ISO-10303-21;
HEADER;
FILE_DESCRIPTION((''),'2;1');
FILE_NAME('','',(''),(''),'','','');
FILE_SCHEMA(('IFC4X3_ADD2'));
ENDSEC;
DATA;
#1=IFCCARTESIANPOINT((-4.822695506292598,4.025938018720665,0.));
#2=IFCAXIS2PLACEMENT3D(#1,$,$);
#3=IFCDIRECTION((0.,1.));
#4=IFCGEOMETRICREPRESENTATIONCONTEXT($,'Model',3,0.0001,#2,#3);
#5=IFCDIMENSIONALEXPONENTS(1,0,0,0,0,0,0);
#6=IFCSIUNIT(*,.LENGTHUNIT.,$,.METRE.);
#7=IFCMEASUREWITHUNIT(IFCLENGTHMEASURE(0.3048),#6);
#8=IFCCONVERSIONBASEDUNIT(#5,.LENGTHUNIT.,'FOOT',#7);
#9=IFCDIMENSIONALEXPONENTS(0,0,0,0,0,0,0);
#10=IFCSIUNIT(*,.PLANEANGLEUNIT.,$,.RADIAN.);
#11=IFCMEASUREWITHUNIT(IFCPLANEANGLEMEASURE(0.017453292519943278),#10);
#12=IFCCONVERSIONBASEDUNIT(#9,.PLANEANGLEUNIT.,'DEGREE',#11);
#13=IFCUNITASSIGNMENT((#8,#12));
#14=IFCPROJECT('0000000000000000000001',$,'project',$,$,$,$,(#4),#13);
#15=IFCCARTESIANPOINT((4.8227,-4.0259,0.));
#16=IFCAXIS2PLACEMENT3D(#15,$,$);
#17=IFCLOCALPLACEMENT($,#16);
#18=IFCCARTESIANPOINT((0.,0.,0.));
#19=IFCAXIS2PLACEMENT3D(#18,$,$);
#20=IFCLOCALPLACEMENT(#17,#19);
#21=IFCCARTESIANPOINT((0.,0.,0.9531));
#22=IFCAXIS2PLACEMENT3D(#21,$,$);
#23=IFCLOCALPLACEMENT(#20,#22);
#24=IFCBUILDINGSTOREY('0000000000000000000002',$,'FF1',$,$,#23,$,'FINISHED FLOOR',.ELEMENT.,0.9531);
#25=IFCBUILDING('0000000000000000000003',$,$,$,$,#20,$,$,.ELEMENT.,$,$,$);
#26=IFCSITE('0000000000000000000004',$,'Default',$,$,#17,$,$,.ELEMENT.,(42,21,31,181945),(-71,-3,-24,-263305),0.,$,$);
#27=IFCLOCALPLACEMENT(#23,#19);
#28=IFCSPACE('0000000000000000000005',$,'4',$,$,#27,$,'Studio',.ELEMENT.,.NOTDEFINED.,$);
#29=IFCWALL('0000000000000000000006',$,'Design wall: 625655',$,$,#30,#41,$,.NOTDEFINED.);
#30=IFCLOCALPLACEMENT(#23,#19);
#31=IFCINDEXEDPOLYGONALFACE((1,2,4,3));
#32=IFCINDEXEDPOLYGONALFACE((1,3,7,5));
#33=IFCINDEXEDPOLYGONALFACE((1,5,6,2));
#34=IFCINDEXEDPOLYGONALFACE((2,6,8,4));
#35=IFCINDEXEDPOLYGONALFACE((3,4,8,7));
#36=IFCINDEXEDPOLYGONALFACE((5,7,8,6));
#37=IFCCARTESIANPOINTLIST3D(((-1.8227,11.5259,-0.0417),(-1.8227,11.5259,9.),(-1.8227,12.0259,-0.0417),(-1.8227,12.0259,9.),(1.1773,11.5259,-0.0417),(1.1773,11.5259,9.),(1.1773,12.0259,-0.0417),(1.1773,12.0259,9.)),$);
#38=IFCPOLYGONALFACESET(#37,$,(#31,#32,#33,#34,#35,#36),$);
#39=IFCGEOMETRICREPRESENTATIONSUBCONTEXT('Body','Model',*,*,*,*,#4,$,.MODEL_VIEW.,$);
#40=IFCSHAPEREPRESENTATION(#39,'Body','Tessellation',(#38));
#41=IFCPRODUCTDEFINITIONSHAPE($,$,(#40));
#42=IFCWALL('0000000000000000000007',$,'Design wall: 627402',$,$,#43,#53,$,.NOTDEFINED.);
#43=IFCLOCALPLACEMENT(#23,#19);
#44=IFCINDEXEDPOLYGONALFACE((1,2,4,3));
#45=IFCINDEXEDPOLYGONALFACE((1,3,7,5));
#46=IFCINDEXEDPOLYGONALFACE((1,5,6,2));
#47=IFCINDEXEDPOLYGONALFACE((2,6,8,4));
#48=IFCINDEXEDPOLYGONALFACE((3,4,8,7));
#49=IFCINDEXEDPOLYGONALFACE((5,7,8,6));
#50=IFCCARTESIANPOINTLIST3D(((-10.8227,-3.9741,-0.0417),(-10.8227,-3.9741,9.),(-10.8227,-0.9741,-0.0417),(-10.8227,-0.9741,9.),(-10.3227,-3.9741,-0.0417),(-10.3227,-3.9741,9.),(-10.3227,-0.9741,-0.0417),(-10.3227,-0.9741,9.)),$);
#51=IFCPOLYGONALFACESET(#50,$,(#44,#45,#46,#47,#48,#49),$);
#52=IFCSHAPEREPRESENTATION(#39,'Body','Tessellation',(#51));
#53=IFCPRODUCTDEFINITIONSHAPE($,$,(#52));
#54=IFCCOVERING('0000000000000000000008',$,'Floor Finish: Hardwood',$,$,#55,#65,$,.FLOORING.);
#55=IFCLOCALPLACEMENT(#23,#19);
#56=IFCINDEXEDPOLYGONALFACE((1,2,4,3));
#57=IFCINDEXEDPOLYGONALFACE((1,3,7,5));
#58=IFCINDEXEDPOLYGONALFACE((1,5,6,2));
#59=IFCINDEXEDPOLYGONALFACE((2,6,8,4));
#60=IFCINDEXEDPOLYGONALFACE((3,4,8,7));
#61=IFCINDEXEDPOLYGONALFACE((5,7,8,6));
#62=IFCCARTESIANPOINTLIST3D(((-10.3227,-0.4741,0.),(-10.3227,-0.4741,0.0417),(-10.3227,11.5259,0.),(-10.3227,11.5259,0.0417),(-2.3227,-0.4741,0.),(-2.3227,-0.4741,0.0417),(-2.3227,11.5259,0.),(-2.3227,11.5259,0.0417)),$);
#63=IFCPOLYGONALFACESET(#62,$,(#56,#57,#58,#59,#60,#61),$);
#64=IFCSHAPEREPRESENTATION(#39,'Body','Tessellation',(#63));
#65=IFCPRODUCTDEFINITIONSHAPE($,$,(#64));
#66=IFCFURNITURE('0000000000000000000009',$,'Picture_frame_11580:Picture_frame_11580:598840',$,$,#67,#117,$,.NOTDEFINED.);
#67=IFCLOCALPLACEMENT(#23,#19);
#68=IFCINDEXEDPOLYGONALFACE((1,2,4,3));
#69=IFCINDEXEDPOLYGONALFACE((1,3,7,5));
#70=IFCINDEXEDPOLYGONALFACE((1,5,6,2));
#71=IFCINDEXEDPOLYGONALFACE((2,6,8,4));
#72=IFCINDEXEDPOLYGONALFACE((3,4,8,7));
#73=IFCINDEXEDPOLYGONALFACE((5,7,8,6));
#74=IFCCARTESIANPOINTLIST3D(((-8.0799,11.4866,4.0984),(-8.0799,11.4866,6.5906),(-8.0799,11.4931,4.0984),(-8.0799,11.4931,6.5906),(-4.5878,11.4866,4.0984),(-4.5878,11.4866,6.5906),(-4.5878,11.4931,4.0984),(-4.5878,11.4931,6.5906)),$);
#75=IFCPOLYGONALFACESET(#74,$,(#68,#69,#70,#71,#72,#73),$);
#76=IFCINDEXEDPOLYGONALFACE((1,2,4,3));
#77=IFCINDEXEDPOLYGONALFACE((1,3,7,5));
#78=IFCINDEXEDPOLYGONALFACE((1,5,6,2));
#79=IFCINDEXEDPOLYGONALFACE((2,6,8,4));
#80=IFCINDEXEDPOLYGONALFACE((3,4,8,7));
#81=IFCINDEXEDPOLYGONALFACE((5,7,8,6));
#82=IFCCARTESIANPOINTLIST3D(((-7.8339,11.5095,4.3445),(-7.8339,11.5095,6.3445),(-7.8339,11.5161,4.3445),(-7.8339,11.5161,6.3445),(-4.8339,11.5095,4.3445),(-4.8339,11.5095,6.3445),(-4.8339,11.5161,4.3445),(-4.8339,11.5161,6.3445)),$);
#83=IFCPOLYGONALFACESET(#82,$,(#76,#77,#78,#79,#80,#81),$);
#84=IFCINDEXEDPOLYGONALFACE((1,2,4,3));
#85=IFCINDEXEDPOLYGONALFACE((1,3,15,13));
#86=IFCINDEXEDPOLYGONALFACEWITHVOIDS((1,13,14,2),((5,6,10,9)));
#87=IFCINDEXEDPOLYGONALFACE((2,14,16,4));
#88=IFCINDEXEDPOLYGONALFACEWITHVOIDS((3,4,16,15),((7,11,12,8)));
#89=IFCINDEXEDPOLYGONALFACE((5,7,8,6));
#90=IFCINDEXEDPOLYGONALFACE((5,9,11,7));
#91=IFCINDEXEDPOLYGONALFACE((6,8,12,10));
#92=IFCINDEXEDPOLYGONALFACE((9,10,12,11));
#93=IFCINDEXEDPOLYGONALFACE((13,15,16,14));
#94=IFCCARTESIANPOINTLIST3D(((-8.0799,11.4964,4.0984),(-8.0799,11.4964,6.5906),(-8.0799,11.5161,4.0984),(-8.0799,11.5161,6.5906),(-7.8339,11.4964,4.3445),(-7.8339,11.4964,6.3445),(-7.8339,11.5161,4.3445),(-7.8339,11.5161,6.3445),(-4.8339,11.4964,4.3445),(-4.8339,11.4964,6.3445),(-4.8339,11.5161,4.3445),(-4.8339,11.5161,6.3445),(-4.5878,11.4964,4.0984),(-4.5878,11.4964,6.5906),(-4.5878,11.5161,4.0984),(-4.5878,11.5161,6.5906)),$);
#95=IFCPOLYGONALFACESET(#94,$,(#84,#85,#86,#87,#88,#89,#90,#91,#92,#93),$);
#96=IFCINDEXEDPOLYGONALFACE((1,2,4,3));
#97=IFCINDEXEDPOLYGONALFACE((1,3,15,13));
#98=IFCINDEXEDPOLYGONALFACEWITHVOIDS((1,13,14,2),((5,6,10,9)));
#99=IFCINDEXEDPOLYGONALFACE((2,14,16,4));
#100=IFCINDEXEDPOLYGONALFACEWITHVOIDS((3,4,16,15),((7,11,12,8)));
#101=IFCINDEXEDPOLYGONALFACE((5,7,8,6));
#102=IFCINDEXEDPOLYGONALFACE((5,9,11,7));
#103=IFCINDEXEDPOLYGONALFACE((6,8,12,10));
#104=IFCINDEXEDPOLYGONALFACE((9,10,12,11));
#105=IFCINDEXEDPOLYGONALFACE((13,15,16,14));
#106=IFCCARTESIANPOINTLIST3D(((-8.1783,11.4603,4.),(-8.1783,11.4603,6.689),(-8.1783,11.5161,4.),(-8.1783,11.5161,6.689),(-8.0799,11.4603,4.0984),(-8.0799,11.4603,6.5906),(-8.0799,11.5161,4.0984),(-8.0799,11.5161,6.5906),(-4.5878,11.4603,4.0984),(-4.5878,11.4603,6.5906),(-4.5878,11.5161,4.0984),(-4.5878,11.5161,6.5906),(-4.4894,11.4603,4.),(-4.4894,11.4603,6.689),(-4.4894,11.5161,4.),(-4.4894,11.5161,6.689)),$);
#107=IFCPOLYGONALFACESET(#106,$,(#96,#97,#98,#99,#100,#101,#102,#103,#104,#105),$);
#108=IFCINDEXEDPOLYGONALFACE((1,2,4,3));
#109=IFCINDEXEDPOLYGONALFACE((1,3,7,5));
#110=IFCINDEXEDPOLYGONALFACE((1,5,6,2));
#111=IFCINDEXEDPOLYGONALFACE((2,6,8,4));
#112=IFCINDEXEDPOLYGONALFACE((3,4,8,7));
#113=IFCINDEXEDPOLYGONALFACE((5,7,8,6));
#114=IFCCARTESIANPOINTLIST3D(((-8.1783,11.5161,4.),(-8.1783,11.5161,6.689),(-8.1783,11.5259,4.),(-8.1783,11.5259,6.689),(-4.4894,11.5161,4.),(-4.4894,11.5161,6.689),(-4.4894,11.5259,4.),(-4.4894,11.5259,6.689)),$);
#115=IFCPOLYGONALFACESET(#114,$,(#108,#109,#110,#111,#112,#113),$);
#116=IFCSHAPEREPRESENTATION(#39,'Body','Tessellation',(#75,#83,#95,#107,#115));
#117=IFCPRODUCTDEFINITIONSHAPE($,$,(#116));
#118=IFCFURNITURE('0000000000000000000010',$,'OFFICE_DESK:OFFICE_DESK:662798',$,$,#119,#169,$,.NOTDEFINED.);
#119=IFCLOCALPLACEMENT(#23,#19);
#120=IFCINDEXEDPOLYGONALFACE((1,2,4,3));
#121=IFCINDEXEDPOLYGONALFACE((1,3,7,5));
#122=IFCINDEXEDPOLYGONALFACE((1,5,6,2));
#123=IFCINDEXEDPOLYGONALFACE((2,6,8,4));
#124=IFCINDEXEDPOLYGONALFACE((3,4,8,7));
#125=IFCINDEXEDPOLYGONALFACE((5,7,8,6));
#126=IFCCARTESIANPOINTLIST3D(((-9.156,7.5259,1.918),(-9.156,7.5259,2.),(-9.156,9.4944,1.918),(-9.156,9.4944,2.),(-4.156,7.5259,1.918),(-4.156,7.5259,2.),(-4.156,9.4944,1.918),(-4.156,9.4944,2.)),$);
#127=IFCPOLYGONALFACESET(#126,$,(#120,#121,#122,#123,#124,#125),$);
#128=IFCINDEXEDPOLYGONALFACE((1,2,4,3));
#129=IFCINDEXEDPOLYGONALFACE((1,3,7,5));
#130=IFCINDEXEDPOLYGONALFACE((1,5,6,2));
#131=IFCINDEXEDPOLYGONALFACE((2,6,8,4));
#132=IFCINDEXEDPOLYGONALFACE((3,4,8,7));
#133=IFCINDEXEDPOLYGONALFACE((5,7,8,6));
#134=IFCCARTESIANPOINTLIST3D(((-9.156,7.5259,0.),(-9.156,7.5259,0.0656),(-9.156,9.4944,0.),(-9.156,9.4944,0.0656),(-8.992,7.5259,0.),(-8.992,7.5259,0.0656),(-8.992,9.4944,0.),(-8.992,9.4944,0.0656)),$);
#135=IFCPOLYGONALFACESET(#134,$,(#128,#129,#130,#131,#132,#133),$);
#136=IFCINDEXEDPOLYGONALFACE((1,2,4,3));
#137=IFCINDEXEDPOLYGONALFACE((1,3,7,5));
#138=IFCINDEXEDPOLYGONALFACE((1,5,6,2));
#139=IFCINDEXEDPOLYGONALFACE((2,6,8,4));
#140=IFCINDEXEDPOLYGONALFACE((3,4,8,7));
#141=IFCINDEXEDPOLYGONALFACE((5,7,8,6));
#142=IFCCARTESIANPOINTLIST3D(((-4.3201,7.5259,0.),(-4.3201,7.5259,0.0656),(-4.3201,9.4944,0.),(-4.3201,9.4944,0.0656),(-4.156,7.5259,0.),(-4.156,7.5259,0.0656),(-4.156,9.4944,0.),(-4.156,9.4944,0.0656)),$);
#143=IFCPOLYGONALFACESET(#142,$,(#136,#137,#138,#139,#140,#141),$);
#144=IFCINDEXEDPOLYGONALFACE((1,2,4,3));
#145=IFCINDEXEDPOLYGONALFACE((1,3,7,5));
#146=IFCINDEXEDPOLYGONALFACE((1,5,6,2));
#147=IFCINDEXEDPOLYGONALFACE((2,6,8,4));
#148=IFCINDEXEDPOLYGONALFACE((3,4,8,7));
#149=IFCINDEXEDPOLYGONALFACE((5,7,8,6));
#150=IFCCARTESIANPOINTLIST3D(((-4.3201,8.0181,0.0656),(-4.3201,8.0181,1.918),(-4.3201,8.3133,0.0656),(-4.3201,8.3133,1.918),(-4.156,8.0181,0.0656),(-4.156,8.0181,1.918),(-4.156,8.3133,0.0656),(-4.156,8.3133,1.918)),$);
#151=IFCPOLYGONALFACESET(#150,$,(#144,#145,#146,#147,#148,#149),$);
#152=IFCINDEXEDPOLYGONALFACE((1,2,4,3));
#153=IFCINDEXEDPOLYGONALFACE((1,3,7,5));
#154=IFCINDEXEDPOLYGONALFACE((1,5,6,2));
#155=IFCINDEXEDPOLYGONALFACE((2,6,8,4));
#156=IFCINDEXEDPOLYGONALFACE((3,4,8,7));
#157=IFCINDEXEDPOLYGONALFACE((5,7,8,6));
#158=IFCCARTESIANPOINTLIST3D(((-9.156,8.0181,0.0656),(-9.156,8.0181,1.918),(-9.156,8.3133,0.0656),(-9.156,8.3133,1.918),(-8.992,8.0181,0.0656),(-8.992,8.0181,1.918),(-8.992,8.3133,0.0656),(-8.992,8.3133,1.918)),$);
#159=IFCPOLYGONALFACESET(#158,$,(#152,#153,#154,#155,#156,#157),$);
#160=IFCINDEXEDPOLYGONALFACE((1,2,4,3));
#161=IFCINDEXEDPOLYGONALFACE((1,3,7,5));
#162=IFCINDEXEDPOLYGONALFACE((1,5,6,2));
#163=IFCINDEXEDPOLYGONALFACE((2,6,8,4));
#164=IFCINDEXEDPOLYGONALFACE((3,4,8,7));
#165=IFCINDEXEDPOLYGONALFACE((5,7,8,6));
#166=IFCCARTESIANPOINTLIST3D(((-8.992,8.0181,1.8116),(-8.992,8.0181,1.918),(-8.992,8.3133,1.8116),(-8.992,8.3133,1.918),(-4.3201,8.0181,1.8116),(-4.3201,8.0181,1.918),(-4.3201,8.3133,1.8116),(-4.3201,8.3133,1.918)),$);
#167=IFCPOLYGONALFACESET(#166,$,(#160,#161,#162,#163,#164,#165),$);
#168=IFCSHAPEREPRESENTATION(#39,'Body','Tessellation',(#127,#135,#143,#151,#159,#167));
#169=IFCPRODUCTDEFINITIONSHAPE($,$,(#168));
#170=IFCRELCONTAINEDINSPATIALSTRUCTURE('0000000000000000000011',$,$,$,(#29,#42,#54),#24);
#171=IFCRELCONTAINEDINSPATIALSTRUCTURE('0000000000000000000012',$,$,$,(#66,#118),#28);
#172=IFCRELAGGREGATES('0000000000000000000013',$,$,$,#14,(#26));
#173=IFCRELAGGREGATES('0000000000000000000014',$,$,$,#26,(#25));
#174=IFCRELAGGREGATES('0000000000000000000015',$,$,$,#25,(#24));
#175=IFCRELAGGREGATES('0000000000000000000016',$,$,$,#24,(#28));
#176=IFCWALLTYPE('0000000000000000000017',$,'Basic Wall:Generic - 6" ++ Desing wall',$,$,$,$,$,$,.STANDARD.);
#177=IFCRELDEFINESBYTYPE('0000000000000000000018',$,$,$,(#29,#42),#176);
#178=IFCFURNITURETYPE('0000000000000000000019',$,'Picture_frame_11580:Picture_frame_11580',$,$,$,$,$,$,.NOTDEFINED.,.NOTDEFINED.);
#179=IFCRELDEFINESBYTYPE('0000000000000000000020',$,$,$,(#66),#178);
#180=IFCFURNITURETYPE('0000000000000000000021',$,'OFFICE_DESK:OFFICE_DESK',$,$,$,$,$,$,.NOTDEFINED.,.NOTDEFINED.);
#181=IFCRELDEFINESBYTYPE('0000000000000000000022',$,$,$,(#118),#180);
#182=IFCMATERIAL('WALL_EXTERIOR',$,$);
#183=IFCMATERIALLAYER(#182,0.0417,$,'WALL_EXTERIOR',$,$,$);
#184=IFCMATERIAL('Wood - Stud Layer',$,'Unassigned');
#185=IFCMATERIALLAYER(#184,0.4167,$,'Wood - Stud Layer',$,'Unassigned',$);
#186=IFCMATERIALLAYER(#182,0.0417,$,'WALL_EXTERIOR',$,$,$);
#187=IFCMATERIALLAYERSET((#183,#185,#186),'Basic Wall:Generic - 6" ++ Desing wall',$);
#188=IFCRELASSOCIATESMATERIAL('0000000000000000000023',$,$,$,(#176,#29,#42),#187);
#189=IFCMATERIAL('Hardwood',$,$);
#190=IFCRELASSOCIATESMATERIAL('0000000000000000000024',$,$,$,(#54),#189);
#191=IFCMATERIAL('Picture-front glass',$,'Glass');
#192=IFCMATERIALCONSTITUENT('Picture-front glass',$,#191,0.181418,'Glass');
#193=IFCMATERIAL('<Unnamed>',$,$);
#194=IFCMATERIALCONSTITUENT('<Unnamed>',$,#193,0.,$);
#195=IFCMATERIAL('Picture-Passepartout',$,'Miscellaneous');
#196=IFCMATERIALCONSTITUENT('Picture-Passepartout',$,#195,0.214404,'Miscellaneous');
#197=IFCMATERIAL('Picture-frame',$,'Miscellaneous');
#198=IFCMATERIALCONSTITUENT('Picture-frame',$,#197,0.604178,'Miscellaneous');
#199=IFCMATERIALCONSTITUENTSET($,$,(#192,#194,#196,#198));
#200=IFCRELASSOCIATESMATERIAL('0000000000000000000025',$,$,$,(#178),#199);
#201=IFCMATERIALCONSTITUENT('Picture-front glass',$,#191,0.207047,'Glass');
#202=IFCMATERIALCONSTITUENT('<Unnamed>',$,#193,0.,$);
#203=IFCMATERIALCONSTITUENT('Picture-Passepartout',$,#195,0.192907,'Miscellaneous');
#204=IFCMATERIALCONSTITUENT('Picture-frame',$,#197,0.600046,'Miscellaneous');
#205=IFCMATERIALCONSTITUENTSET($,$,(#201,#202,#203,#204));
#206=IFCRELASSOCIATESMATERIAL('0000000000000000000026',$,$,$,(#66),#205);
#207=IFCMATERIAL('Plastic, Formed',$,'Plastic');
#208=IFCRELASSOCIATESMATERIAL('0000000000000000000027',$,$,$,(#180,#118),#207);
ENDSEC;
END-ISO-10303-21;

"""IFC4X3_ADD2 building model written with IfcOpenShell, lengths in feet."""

from ifc_helpers import new_model, entity, si_unit, converted_unit, direction, frame, frame_2d, origin, origin_2d_with_axis, place, context, subcontext, project, spatial, polyline, rectangle, outline, extrude, source, transform, mapped, material, layer, layer_set, constituent, constituent_set, type_object, type_shapes, element, save


model = new_model("IFC4X3_ADD2")

# Units and contexts
model_context = context("Model", 3, precision=0.0001, world=frame((-4.822695506292598, 4.025938018720665, 0.0)), true_north=direction((0.0, 1.0)))
body_context = subcontext(model_context, "Body", "Model", "MODEL_VIEW")
ifc_project = project(units=[converted_unit("LENGTHUNIT", "FOOT", entity("IfcLengthMeasure", 0.3048), si_unit("LENGTHUNIT", "METRE"), dimensions=[1, 0, 0, 0, 0, 0, 0]), converted_unit("PLANEANGLEUNIT", "DEGREE", entity("IfcPlaneAngleMeasure", 0.017453292519943278), si_unit("PLANEANGLEUNIT", "RADIAN"), dimensions=[0, 0, 0, 0, 0, 0, 0])], contexts=[model_context])

# Site, building, storey
site_placement = place(None, frame((4.8227, -4.0259, 0.0)))
site = spatial("IfcSite", under=ifc_project, at=site_placement, Name="Default", CompositionType="ELEMENT", RefLatitude=(42, 21, 31, 181945), RefLongitude=(-71, -3, -24, -263305), RefElevation=0.0)
building_placement = place(site_placement, origin())
building = spatial("IfcBuilding", under=site, at=building_placement, CompositionType="ELEMENT")
storey_placement = place(building_placement, frame((0.0, 0.0, 0.9531)))
storey = spatial("IfcBuildingStorey", under=building, at=storey_placement, Name="FF1", LongName="FINISHED FLOOR", CompositionType="ELEMENT", Elevation=0.9531)

# Shared definitions
placement_1 = place(building_placement, origin())
placement_2 = place(placement_1, origin())

# Shared definitions
ifc_material_1 = material(Name="WALL_EXTERIOR")
ifc_material_2 = material(Name="Wood - Stud Layer", Category="Unassigned")

# Walls
ifc_layer_1 = layer(ifc_material_1, 0.0417, Name="WALL_EXTERIOR")
ifc_layer_2 = layer(ifc_material_2, 0.4167, Name="Wood - Stud Layer", Category="Unassigned")
ifc_layer_3 = layer(ifc_material_1, 0.0417, Name="WALL_EXTERIOR")
ifc_layer_set_1 = layer_set([ifc_layer_1, ifc_layer_2, ifc_layer_3], Name="Basic Wall:Generic - 6\" ++ Desing wall")
wall_type_1 = type_object("IfcWallType", Name="Basic Wall:Generic - 6\" ++ Desing wall", PredefinedType="STANDARD", material=ifc_layer_set_1)
wall_1_placement = place(storey_placement, frame((-1.8227, 11.7759, -0.0417)))
element("IfcWall", 1, at=wall_1_placement, inside=storey, type_object=wall_type_1, material=ifc_layer_set_1, Name="Design wall: 625655", PredefinedType="NOTDEFINED", context=body_context, shape_type="SweptSolid", body=[
    extrude(rectangle(XDim=3.0, YDim=0.5, at=frame_2d((1.5, 0.0), x_axis=(-1.0, 0.0))), origin(), (0.0, 0.0, 1.0), 9.0417),
])
wall_2_placement = place(storey_placement, frame((-10.5727, -0.9741, -0.0417), z_axis=(0.0, 0.0, 1.0), x_axis=(0.0, -1.0, 0.0)))
element("IfcWall", 2, at=wall_2_placement, inside=storey, type_object=wall_type_1, material=ifc_layer_set_1, Name="Design wall: 627402", PredefinedType="NOTDEFINED", context=body_context, shape_type="SweptSolid", body=[
    extrude(rectangle(XDim=3.0, YDim=0.5, at=frame_2d((1.5, 0.0), x_axis=(-1.0, 0.0))), origin(), (0.0, 0.0, 1.0), 9.0417),
])

# Covering
ifc_material_3 = material(Name="Hardwood")
element("IfcCovering", 3, at=placement_2, inside=storey, material=ifc_material_3, Name="Floor Finish: Hardwood", PredefinedType="FLOORING", context=body_context, shape_type="SweptSolid", body=[
    extrude(outline(polyline([(6.0, -4.0), (-6.0, -4.0), (-6.0, 4.0), (6.0, 4.0), (6.0, -4.0)])), frame((-6.3227, 5.5259, 0.9531), z_axis=(0.0, 0.0, -1.0), x_axis=(0.0, 1.0, 0.0)), (0.0, 0.0, -1.0), 0.0417),
])

# Shared definitions
space_placement = place(storey_placement, origin())
space = spatial("IfcSpace", under=storey, at=space_placement, Name="4", LongName="Studio", CompositionType="ELEMENT", PredefinedType="NOTDEFINED")

# Furniture
ifc_material_4 = material(Name="Picture-front glass", Category="Glass")
ifc_constituent_1 = constituent(ifc_material_4, Name="Picture-front glass", Category="Glass", fraction=0.207047)
ifc_material_5 = material(Name="<Unnamed>")
ifc_constituent_2 = constituent(ifc_material_5, Name="<Unnamed>", fraction=0.0)
ifc_material_6 = material(Name="Picture-Passepartout", Category="Miscellaneous")
ifc_constituent_3 = constituent(ifc_material_6, Name="Picture-Passepartout", Category="Miscellaneous", fraction=0.192907)
ifc_material_7 = material(Name="Picture-frame", Category="Miscellaneous")
ifc_constituent_4 = constituent(ifc_material_7, Name="Picture-frame", Category="Miscellaneous", fraction=0.600046)
ifc_constituent_set_1 = constituent_set(constituents=[ifc_constituent_1, ifc_constituent_2, ifc_constituent_3, ifc_constituent_4])
ifc_constituent_5 = constituent(ifc_material_4, Name="Picture-front glass", Category="Glass", fraction=0.181418)
ifc_constituent_6 = constituent(ifc_material_5, Name="<Unnamed>", fraction=0.0)
ifc_constituent_7 = constituent(ifc_material_6, Name="Picture-Passepartout", Category="Miscellaneous", fraction=0.214404)
ifc_constituent_8 = constituent(ifc_material_7, Name="Picture-frame", Category="Miscellaneous", fraction=0.604178)
ifc_constituent_set_2 = constituent_set(constituents=[ifc_constituent_5, ifc_constituent_6, ifc_constituent_7, ifc_constituent_8])
furniture_type_1 = type_object("IfcFurnitureType", Name="Picture_frame_11580:Picture_frame_11580", AssemblyPlace="NOTDEFINED", PredefinedType="NOTDEFINED", material=ifc_constituent_set_2)
shared_shape_1 = source(origin(), body_context, "Body", "SweptSolid", [
    extrude(rectangle(XDim=0.0066, YDim=3.4921, at=frame_2d((0.0, 0.0), x_axis=(1.0, 0.0))), frame((1.8445, -0.0361, 0.0984), z_axis=(0.0, 0.0, 1.0), x_axis=(0.0, 1.0, 0.0)), (0.0, 0.0, 1.0), 2.4921),
    extrude(rectangle(XDim=0.0066, YDim=3.0, at=origin_2d_with_axis()), frame((1.8445, -0.0131, 0.3445), z_axis=(0.0, 0.0, 1.0), x_axis=(0.0, 1.0, 0.0)), (0.0, 0.0, 1.0), 2.0),
    extrude(outline(polyline([(-1.2461, -1.7461), (1.2461, -1.7461), (1.2461, 1.7461), (-1.2461, 1.7461), (-1.2461, -1.7461)]), holes=[polyline([(-1.0, -1.5), (-1.0, 1.5), (1.0, 1.5), (1.0, -1.5), (-1.0, -1.5)])]), frame((1.8445, -0.0295, 1.3445), z_axis=(0.0, 1.0, 0.0), x_axis=(0.0, 0.0, -1.0)), (0.0, 0.0, 1.0), 0.0197),
    extrude(outline(polyline([(-1.8445, -1.3445), (1.8445, -1.3445), (1.8445, 1.3445), (-1.8445, 1.3445), (-1.8445, -1.3445)]), holes=[polyline([(1.7461, -1.2461), (-1.7461, -1.2461), (-1.7461, 1.2461), (1.7461, 1.2461), (1.7461, -1.2461)])]), frame((1.8445, -0.0656, 1.3445), z_axis=(0.0, 1.0, 0.0), x_axis=(1.0, 0.0, 0.0)), (0.0, 0.0, 1.0), 0.0558),
    extrude(rectangle(XDim=0.0098, YDim=3.689, at=origin_2d_with_axis()), frame((1.8445, -0.0049, 0.0), z_axis=(0.0, 0.0, 1.0), x_axis=(0.0, 1.0, 0.0)), (0.0, 0.0, 1.0), 2.689),
])
type_shapes(furniture_type_1, [shared_shape_1])
furniture_1_placement = place(space_placement, frame((-8.1783, 11.5259, 4.0)))
element("IfcFurniture", 4, at=furniture_1_placement, inside=space, type_object=furniture_type_1, material=ifc_constituent_set_1, Name="Picture_frame_11580:Picture_frame_11580:598840", PredefinedType="NOTDEFINED", context=body_context, shape_type="MappedRepresentation", body=[
    mapped(shared_shape_1, transform((0.0, 0.0, 0.0), scale=1.0)),
])
ifc_material_8 = material(Name="Plastic, Formed", Category="Plastic")
furniture_type_2 = type_object("IfcFurnitureType", Name="OFFICE_DESK:OFFICE_DESK", AssemblyPlace="NOTDEFINED", PredefinedType="NOTDEFINED", material=ifc_material_8)
shared_shape_2 = source(origin(), body_context, "Body", "SweptSolid", [
    extrude(rectangle(XDim=1.9685, YDim=5.0, at=origin_2d_with_axis()), frame((0.0, -0.9843, 1.918), z_axis=(0.0, 0.0, 1.0), x_axis=(0.0, -1.0, 0.0)), (0.0, 0.0, 1.0), 0.082),
    extrude(rectangle(XDim=0.164, YDim=1.9685, at=origin_2d_with_axis()), frame((2.418, -0.9843, 0.0)), (0.0, 0.0, 1.0), 0.0656),
    extrude(rectangle(XDim=1.9685, YDim=0.164, at=origin_2d_with_axis()), frame((-2.418, -0.9843, 0.0), z_axis=(0.0, 0.0, 1.0), x_axis=(0.0, 1.0, 0.0)), (0.0, 0.0, 1.0), 0.0656),
    extrude(rectangle(XDim=0.2953, YDim=0.164, at=frame_2d((0.0, 0.0), x_axis=(1.0, 0.0))), frame((-2.418, -0.6398, 0.0656), z_axis=(0.0, 0.0, 1.0), x_axis=(0.0, -1.0, 0.0)), (0.0, 0.0, 1.0), 1.8524),
    extrude(rectangle(XDim=0.164, YDim=0.2953, at=origin_2d_with_axis()), frame((2.418, -0.6398, 0.0656), z_axis=(0.0, 0.0, 1.0), x_axis=(-1.0, 0.0, 0.0)), (0.0, 0.0, 1.0), 1.8524),
    extrude(rectangle(XDim=0.2953, YDim=4.6719, at=origin_2d_with_axis()), frame((0.0, -0.6398, 1.8116), z_axis=(0.0, 0.0, 1.0), x_axis=(0.0, 1.0, 0.0)), (0.0, 0.0, 1.0), 0.1064),
])
type_shapes(furniture_type_2, [shared_shape_2])
furniture_2_placement = place(space_placement, frame((-6.656, 7.5259, 0.0), z_axis=(0.0, 0.0, 1.0), x_axis=(-1.0, 0.0, 0.0)))
element("IfcFurniture", 5, at=furniture_2_placement, inside=space, type_object=furniture_type_2, material=ifc_material_8, Name="OFFICE_DESK:OFFICE_DESK:662798", PredefinedType="NOTDEFINED", context=body_context, shape_type="MappedRepresentation", body=[
    mapped(shared_shape_2, transform((0.0, 0.0, 0.0), scale=1.0)),
])

save(model, "model.ifc")
